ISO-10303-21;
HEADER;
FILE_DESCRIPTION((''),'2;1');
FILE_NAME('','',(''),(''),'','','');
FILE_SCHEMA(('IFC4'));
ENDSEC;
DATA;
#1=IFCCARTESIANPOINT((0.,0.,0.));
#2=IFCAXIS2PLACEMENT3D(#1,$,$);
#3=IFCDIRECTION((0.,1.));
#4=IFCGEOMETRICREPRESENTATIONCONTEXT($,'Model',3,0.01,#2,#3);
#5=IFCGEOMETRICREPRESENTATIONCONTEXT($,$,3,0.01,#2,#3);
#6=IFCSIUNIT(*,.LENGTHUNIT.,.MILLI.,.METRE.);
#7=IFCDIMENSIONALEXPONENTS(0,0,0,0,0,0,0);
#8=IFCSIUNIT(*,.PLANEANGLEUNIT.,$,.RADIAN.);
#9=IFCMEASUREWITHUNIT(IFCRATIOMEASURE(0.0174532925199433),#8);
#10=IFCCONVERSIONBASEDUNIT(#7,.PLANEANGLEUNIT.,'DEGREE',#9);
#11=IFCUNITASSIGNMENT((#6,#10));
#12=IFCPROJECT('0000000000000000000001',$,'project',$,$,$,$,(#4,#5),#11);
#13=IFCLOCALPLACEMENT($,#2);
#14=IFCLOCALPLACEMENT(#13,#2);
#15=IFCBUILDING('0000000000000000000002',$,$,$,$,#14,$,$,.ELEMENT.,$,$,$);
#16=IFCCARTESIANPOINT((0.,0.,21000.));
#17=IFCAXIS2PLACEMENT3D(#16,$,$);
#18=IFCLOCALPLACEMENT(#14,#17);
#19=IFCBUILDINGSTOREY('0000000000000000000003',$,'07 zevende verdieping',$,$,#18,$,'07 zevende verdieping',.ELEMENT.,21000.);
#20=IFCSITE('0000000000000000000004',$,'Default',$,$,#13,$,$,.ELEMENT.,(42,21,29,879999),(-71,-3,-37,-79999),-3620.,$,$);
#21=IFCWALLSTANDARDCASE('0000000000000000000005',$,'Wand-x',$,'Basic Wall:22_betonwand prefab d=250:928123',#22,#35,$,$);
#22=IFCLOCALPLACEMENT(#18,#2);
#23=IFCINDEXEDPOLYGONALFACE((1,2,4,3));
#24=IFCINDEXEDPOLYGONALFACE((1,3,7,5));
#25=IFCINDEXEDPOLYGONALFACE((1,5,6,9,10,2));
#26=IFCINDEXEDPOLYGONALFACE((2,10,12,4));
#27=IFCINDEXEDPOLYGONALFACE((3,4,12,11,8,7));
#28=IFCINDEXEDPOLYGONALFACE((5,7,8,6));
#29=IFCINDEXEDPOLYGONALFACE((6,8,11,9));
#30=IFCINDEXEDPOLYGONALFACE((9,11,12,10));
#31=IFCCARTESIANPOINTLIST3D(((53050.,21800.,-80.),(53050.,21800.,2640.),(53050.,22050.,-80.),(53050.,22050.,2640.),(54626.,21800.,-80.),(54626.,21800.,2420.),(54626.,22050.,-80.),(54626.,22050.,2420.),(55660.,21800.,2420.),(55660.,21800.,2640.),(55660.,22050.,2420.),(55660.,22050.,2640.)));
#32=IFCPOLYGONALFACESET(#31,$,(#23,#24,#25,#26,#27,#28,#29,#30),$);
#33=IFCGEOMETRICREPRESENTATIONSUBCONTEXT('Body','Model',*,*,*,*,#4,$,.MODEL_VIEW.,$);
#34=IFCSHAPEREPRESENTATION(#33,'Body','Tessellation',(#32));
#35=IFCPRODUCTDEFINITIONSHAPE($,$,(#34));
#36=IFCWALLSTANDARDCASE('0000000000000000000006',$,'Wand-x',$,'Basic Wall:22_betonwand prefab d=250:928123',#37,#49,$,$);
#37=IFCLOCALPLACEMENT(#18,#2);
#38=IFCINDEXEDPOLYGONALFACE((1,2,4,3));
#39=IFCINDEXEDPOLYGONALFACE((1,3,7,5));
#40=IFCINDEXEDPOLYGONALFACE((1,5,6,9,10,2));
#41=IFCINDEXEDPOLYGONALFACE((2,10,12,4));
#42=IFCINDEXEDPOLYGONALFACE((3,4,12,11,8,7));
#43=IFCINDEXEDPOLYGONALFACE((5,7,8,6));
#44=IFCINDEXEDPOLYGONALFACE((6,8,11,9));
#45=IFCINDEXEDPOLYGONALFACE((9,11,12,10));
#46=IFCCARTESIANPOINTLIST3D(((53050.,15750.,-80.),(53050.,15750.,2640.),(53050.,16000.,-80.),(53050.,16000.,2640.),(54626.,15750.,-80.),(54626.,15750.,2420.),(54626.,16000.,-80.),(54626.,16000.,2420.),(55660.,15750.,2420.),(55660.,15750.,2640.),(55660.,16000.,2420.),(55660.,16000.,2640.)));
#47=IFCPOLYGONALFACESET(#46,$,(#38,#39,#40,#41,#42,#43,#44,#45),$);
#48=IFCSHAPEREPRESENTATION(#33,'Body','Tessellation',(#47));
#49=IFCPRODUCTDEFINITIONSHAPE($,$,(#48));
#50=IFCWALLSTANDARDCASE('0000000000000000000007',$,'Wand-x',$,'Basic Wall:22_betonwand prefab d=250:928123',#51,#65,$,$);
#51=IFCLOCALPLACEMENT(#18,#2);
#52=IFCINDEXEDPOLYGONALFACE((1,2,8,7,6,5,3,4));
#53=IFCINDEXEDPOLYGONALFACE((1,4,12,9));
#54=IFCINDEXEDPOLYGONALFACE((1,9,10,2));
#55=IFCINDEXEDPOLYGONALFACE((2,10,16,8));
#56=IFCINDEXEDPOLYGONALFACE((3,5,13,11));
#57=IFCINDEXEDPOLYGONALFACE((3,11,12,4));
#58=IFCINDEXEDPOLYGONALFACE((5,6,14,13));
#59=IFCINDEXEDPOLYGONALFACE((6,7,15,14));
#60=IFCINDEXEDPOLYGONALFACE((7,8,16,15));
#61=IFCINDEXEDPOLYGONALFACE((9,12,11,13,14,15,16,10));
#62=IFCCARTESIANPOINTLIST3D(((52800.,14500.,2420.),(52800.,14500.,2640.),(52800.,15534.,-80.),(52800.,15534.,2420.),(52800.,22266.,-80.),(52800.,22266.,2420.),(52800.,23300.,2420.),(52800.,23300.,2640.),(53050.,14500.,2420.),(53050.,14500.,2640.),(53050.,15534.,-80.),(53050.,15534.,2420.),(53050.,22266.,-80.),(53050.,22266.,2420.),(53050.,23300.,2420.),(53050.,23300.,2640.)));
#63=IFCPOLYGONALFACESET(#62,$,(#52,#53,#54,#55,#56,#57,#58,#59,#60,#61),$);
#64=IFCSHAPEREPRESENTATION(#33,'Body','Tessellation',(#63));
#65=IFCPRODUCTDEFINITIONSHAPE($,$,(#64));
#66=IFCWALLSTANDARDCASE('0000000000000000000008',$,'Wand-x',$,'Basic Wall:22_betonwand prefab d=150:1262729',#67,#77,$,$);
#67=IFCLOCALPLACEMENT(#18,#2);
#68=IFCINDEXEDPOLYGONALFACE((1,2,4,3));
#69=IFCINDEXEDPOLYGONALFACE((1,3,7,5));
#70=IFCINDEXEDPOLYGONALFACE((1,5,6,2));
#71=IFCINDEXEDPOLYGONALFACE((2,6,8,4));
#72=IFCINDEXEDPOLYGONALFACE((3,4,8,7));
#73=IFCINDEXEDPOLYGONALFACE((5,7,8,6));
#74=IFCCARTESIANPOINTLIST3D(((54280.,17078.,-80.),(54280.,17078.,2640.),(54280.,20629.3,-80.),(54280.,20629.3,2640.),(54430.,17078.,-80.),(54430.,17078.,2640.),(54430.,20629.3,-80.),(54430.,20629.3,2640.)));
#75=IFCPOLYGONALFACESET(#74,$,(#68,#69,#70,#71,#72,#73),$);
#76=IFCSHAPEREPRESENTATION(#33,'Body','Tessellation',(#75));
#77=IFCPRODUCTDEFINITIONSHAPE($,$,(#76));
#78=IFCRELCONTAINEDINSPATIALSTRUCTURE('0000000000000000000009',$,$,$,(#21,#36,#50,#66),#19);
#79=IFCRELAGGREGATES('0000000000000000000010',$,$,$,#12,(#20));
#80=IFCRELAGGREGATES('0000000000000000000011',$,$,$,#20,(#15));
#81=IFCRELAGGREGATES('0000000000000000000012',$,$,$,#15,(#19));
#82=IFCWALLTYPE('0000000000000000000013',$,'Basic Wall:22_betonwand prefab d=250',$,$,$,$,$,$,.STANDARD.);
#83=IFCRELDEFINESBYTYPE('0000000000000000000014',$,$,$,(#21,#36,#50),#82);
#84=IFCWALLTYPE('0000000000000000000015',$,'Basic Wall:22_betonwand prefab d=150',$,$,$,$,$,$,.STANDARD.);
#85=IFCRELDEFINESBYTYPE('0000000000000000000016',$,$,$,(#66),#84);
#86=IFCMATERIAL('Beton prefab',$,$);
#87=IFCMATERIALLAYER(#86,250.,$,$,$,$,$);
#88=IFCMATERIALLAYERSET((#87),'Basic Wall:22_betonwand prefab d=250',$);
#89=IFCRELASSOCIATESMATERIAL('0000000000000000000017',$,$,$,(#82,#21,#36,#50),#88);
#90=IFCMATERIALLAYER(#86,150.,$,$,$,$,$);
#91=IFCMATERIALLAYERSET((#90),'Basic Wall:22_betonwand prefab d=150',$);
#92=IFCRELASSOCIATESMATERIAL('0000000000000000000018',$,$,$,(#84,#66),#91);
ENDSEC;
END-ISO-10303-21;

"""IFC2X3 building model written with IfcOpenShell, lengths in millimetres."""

from ifc_helpers import new_model, entity, si_unit, converted_unit, direction, frame, frame_2d, origin, place, context, subcontext, project, spatial, rectangle, extrude, material, layer, layer_set, layer_usage, type_object, element, save


model = new_model("IFC2X3")

# Units and contexts
model_context = context("Model", 3, precision=0.01, world=origin(), true_north=direction((0.0, 1.0)))
context_of_model = context(None, 3, precision=0.01, world=origin(), true_north=direction((0.0, 1.0)))
body_context = subcontext(model_context, "Body", "Model", "MODEL_VIEW")
ifc_project = project(units=[si_unit("LENGTHUNIT", "METRE", prefix="MILLI"), converted_unit("PLANEANGLEUNIT", "DEGREE", entity("IfcRatioMeasure", 0.0174532925199433), si_unit("PLANEANGLEUNIT", "RADIAN"), dimensions=[0, 0, 0, 0, 0, 0, 0])], contexts=[model_context, context_of_model])

# Site, building, storey
site_placement = place(None, origin())
site = spatial("IfcSite", under=ifc_project, at=site_placement, Name="Default", CompositionType="ELEMENT", RefLatitude=(42, 21, 29, 879999), RefLongitude=(-71, -3, -37, -79999), RefElevation=-3620.0)
building_placement = place(site_placement, origin())
building = spatial("IfcBuilding", under=site, at=building_placement, CompositionType="ELEMENT")
storey_placement = place(building_placement, frame((0.0, 0.0, 21000.0)))
storey = spatial("IfcBuildingStorey", under=building, at=storey_placement, Name="07 zevende verdieping", LongName="07 zevende verdieping", CompositionType="ELEMENT", Elevation=21000.0)

# Shared definitions
ifc_material_1 = material(Name="Beton prefab")

# Walls, openings
ifc_layer_1 = layer(ifc_material_1, 250.0)
ifc_layer_set_1 = layer_set([ifc_layer_1], Name="Basic Wall:22_betonwand prefab d=250")
ifc_layer_usage_1 = layer_usage(ifc_layer_set_1, "AXIS2", "NEGATIVE", 125.0)
wall_type_1 = type_object("IfcWallType", Name="Basic Wall:22_betonwand prefab d=250", PredefinedType="STANDARD", material=ifc_layer_set_1)
wall_1_placement = place(storey_placement, frame((53050.0, 21925.0, -80.0)))
wall_1 = element("IfcWallStandardCase", 1, at=wall_1_placement, inside=storey, type_object=wall_type_1, material=ifc_layer_usage_1, Name="Wand-x", ObjectType="Basic Wall:22_betonwand prefab d=250:928123", context=body_context, shape_type="SweptSolid", body=[
    extrude(rectangle(XDim=2610.0, YDim=250.0, at=frame_2d((1305.0, 0.0), x_axis=(-1.0, 0.0))), origin(), (0.0, 0.0, 1.0), 2720.0),
])
opening_1_placement = place(wall_1_placement, frame((-53050.0, -21925.0, 80.0)))
element("IfcOpeningElement", 2, at=opening_1_placement, cuts=wall_1, ObjectType="Opening", context=body_context, shape_type="SweptSolid", body=[
    extrude(rectangle(XDim=2500.0, YDim=1034.0, at=frame_2d((0.0, 0.0), x_axis=(1.0, 0.0))), frame((55143.0, 21525.0, 1170.0), z_axis=(0.0, 1.0, 0.0), x_axis=(0.0, 0.0, -1.0)), (0.0, 0.0, 1.0), 800.0),
])
ifc_layer_usage_2 = layer_usage(ifc_layer_set_1, "AXIS2", "POSITIVE", -125.0)
wall_2_placement = place(storey_placement, frame((53050.0, 15875.0, -80.0)))
wall_2 = element("IfcWallStandardCase", 3, at=wall_2_placement, inside=storey, type_object=wall_type_1, material=ifc_layer_usage_2, Name="Wand-x", ObjectType="Basic Wall:22_betonwand prefab d=250:928123", context=body_context, shape_type="SweptSolid", body=[
    extrude(rectangle(XDim=2610.0, YDim=250.0, at=frame_2d((1305.0, 0.0), x_axis=(-1.0, 0.0))), origin(), (0.0, 0.0, 1.0), 2720.0),
])
opening_2_placement = place(wall_2_placement, frame((-53050.0, -15875.0, 80.0)))
element("IfcOpeningElement", 4, at=opening_2_placement, cuts=wall_2, ObjectType="Opening", context=body_context, shape_type="SweptSolid", body=[
    extrude(rectangle(XDim=2500.0, YDim=1034.0, at=frame_2d((0.0, 0.0), x_axis=(1.0, 0.0))), frame((55143.0, 15475.0, 1170.0), z_axis=(0.0, 1.0, 0.0), x_axis=(0.0, 0.0, -1.0)), (0.0, 0.0, 1.0), 800.0),
])

# Wall, openings
ifc_layer_usage_3 = layer_usage(ifc_layer_set_1, "AXIS2", "NEGATIVE", 125.0)
wall_3_placement = place(storey_placement, frame((52925.0, 14500.0, -80.0), z_axis=(0.0, 0.0, 1.0), x_axis=(0.0, 1.0, 0.0)))
wall_3 = element("IfcWallStandardCase", 5, at=wall_3_placement, inside=storey, type_object=wall_type_1, material=ifc_layer_usage_3, Name="Wand-x", ObjectType="Basic Wall:22_betonwand prefab d=250:928123", context=body_context, shape_type="SweptSolid", body=[
    extrude(rectangle(XDim=8800.0, YDim=250.0, at=frame_2d((4400.0, 0.0), x_axis=(-1.0, 0.0))), origin(), (0.0, 0.0, 1.0), 2720.0),
])
opening_3_placement = place(wall_3_placement, frame((-14500.0, 52925.0, 80.0), z_axis=(0.0, 0.0, 1.0), x_axis=(0.0, -1.0, 0.0)))
element("IfcOpeningElement", 6, at=opening_3_placement, cuts=wall_3, ObjectType="Opening", context=body_context, shape_type="SweptSolid", body=[
    extrude(rectangle(XDim=2500.0, YDim=1034.0, at=frame_2d((0.0, 0.0), x_axis=(1.0, 0.0))), frame((53325.0, 15017.0, 1170.0), z_axis=(-1.0, 0.0, 0.0), x_axis=(0.0, 0.0, -1.0)), (0.0, 0.0, 1.0), 800.0),
])
opening_4_placement = place(wall_3_placement, frame((-14500.0, 52925.0, 80.0), z_axis=(0.0, 0.0, 1.0), x_axis=(0.0, -1.0, 0.0)))
element("IfcOpeningElement", 7, at=opening_4_placement, cuts=wall_3, ObjectType="Opening", context=body_context, shape_type="SweptSolid", body=[
    extrude(rectangle(XDim=2500.0, YDim=1034.0, at=frame_2d((0.0, 0.0), x_axis=(0.0, 1.0))), frame((53325.0, 22783.0, 1170.0), z_axis=(-1.0, 0.0, 0.0), x_axis=(0.0, 1.0, 0.0)), (0.0, 0.0, 1.0), 800.0),
])

# Wall
ifc_layer_2 = layer(ifc_material_1, 150.0)
ifc_layer_set_2 = layer_set([ifc_layer_2], Name="Basic Wall:22_betonwand prefab d=150")
ifc_layer_usage_4 = layer_usage(ifc_layer_set_2, "AXIS2", "NEGATIVE", 75.0)
wall_type_2 = type_object("IfcWallType", Name="Basic Wall:22_betonwand prefab d=150", PredefinedType="STANDARD", material=ifc_layer_set_2)
wall_4_placement = place(storey_placement, frame((54355.0, 17078.0, -80.0), z_axis=(0.0, 0.0, 1.0), x_axis=(0.0, 1.0, 0.0)))
element("IfcWallStandardCase", 8, at=wall_4_placement, inside=storey, type_object=wall_type_2, material=ifc_layer_usage_4, Name="Wand-x", ObjectType="Basic Wall:22_betonwand prefab d=150:1262729", context=body_context, shape_type="SweptSolid", body=[
    extrude(rectangle(XDim=3551.3, YDim=150.0, at=frame_2d((1775.7, 0.0), x_axis=(-1.0, 0.0))), origin(), (0.0, 0.0, 1.0), 2720.0),
])

save(model, "model.ifc")
